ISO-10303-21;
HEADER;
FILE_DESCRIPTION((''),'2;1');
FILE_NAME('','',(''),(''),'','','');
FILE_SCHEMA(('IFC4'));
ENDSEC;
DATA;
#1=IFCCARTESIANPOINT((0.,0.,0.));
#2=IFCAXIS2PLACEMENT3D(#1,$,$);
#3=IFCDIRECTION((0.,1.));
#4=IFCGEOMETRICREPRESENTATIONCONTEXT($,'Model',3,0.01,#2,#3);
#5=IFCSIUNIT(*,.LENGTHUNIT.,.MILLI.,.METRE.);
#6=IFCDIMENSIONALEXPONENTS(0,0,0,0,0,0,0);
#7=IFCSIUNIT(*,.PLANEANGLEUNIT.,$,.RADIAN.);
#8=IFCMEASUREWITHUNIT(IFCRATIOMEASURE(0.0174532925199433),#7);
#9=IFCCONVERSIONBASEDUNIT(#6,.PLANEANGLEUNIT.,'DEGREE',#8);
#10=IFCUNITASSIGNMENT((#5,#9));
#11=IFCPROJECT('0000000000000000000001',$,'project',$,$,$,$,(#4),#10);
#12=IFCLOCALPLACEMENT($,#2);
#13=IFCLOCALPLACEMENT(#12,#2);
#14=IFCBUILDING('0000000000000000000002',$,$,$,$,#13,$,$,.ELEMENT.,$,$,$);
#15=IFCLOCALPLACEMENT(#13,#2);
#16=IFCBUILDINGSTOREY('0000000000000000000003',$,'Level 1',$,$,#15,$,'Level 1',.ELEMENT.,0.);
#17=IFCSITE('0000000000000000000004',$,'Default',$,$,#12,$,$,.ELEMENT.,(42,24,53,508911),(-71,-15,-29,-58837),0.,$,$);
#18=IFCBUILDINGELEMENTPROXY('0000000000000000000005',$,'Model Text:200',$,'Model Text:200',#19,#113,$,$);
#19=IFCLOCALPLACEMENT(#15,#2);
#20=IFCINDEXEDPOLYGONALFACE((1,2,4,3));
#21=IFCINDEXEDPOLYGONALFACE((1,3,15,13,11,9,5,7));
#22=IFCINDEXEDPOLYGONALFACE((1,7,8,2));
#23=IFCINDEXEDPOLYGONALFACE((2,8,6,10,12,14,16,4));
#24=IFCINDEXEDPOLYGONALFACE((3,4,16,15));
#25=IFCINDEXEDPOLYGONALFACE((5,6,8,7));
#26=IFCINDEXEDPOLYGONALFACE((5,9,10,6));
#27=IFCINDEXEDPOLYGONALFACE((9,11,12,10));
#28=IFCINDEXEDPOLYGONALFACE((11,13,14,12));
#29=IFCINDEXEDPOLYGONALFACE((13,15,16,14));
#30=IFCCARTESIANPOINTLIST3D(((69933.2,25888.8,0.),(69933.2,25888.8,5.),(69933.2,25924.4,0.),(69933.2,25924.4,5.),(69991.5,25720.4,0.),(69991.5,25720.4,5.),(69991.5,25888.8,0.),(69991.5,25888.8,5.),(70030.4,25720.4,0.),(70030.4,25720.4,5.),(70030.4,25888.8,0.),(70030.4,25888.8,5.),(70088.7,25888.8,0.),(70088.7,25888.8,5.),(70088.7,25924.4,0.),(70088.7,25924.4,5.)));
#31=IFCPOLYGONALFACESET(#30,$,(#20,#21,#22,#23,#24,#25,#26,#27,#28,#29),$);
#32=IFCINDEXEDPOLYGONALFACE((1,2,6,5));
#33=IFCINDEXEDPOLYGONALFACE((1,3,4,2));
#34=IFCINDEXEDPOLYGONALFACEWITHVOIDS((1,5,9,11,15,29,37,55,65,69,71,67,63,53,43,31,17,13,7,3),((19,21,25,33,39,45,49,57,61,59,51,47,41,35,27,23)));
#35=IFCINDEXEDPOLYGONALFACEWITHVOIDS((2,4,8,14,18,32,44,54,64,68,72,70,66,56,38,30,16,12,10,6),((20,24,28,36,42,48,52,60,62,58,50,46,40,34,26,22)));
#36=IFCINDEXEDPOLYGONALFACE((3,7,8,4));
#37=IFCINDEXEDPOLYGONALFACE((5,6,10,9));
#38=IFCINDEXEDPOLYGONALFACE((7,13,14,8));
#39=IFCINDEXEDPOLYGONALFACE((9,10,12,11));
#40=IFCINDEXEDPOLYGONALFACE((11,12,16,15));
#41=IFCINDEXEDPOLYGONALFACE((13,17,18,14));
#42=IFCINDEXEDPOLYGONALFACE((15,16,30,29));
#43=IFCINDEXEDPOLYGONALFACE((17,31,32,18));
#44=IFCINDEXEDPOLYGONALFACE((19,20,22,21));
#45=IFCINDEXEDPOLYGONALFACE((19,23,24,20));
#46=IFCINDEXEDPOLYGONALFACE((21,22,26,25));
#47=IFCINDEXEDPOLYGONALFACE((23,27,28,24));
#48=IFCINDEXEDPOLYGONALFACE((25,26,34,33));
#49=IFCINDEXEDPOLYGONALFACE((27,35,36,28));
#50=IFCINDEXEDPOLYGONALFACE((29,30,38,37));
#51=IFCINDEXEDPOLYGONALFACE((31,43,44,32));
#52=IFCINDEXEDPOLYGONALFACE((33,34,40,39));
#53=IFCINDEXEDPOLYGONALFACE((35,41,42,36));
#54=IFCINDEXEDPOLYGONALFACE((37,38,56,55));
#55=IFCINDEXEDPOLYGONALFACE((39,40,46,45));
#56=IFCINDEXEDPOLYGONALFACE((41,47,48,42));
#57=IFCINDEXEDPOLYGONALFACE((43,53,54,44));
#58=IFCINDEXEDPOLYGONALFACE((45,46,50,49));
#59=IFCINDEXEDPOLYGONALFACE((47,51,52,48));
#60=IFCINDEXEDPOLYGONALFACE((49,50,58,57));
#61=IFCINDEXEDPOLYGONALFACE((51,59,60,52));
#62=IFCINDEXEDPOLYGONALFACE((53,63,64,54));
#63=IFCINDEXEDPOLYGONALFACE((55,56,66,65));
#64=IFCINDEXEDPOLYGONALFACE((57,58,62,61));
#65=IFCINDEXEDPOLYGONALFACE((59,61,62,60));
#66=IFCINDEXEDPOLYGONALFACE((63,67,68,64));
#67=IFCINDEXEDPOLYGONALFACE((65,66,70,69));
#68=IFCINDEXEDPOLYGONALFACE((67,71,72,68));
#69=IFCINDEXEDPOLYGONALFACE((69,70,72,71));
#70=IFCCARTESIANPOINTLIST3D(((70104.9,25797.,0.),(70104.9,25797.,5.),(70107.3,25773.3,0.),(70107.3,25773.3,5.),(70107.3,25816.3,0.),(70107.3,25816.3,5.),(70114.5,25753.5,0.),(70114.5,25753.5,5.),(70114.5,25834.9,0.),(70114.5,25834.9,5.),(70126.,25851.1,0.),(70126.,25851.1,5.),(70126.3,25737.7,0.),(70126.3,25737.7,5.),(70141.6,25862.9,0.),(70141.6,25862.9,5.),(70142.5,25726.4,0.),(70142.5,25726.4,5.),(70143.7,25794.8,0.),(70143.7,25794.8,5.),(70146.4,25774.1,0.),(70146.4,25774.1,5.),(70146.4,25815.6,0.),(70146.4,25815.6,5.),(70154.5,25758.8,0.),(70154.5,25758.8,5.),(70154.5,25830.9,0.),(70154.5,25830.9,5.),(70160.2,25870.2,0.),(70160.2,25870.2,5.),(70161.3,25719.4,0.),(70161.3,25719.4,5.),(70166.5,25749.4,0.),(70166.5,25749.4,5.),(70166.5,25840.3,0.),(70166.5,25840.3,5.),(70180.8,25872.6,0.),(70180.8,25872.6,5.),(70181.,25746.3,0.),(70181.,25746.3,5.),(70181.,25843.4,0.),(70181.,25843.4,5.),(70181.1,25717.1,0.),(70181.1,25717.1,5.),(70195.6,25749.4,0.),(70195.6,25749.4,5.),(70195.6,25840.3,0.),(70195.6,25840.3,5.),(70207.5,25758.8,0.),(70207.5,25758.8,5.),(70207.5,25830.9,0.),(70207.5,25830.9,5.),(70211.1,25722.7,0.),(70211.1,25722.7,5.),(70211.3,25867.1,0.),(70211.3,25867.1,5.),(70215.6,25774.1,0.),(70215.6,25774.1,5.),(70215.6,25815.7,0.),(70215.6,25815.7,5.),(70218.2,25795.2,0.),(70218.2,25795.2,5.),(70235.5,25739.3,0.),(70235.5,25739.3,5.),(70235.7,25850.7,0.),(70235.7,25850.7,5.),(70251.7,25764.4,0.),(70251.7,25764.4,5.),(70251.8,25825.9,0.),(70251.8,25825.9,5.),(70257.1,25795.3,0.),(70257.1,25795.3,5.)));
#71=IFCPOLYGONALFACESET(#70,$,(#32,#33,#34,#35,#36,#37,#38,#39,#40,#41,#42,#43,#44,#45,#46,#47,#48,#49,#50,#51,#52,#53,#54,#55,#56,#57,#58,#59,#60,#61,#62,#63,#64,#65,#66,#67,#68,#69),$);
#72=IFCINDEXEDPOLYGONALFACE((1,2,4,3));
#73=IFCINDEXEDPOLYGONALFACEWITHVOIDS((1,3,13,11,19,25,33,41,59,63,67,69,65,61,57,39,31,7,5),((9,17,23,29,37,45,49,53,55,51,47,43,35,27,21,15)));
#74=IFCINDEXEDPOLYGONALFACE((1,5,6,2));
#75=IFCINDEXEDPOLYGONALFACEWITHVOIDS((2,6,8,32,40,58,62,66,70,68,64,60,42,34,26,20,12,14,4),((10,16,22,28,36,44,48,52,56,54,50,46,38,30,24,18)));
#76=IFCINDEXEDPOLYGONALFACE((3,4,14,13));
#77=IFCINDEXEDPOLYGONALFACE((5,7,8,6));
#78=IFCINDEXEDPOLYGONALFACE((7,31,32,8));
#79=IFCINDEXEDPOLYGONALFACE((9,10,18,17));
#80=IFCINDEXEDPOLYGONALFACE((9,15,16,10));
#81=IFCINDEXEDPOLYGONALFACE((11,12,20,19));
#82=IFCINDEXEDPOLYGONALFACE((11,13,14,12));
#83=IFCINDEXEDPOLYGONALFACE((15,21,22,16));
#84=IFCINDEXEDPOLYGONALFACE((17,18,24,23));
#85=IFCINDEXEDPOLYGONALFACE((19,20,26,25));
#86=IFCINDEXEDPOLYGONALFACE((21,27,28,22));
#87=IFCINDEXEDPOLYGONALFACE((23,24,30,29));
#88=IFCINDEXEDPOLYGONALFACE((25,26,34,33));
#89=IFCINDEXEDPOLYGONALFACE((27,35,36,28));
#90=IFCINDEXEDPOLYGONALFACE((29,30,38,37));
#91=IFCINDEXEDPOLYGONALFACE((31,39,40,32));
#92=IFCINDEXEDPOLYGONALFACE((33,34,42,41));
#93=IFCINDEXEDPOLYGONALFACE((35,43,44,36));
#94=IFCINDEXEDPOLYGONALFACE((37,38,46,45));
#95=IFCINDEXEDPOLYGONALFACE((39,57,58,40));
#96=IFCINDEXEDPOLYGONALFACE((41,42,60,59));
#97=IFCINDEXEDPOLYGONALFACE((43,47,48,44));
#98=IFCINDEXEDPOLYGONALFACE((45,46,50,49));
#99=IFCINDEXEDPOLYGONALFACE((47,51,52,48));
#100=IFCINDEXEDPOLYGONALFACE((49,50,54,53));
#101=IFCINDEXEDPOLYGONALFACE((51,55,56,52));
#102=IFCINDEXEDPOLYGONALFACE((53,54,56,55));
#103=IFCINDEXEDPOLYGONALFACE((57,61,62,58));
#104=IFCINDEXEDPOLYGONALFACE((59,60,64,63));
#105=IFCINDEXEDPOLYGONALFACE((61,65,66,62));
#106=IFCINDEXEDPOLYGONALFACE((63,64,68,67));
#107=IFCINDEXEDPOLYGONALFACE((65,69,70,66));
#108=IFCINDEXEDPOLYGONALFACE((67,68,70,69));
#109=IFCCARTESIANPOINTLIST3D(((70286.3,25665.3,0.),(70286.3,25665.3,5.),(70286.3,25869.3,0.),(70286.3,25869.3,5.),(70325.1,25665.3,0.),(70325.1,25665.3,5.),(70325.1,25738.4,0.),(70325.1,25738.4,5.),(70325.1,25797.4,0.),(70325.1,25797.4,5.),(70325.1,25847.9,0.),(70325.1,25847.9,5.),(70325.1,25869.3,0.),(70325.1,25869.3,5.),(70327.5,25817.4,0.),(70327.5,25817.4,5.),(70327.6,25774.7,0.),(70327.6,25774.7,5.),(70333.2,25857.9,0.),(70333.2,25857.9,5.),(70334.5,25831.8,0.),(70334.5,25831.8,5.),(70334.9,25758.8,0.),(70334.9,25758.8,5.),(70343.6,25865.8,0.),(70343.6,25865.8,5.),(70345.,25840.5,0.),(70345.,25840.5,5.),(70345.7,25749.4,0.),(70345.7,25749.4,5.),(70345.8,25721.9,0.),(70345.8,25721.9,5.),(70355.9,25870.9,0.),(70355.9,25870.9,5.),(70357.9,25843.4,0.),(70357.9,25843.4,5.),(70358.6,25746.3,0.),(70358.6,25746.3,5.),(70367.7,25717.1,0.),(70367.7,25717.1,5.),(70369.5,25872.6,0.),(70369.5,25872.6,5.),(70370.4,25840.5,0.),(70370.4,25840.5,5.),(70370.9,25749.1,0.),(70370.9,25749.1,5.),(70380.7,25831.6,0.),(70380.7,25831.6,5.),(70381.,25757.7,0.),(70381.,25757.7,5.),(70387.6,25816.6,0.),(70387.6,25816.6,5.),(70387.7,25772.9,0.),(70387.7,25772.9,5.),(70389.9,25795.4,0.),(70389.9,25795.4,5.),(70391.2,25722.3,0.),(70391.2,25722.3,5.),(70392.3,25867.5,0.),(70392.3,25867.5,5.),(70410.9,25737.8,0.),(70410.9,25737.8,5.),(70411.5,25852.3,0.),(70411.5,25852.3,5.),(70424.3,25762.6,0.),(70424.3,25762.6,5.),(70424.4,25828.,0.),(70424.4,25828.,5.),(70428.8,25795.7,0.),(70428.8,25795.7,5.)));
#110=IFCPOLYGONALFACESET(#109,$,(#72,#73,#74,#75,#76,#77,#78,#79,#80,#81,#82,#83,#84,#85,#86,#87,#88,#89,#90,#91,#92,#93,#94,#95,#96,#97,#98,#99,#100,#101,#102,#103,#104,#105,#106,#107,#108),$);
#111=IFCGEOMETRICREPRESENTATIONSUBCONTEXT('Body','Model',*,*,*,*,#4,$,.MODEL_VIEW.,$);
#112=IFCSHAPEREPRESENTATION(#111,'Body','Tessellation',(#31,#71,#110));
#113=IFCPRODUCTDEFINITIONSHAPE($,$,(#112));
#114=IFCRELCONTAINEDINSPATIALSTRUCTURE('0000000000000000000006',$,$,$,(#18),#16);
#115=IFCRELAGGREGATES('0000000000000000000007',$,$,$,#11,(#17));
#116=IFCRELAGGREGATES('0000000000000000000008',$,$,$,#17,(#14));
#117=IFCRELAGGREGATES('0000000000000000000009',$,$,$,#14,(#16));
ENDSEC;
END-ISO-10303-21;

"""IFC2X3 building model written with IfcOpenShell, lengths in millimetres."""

from ifc_helpers import new_model, entity, si_unit, converted_unit, direction, frame, origin, place, context, subcontext, project, spatial, polyline, outline, extrude, element, save


model = new_model("IFC2X3")

# Units and contexts
model_context = context("Model", 3, precision=0.01, world=origin(), true_north=direction((0.0, 1.0)))
body_context = subcontext(model_context, "Body", "Model", "MODEL_VIEW")
ifc_project = project(units=[si_unit("LENGTHUNIT", "METRE", prefix="MILLI"), converted_unit("PLANEANGLEUNIT", "DEGREE", entity("IfcRatioMeasure", 0.0174532925199433), si_unit("PLANEANGLEUNIT", "RADIAN"), dimensions=[0, 0, 0, 0, 0, 0, 0])], contexts=[model_context])

# Site, building, storey
site_placement = place(None, origin())
site = spatial("IfcSite", under=ifc_project, at=site_placement, Name="Default", CompositionType="ELEMENT", RefLatitude=(42, 24, 53, 508911), RefLongitude=(-71, -15, -29, -58837), RefElevation=0.0)
building_placement = place(site_placement, origin())
building = spatial("IfcBuilding", under=site, at=building_placement, CompositionType="ELEMENT")
storey_placement = place(building_placement, origin())
storey = spatial("IfcBuildingStorey", under=building, at=storey_placement, Name="Level 1", LongName="Level 1", CompositionType="ELEMENT", Elevation=0.0)

# Building element proxy
proxy_1_placement = place(storey_placement, origin())
element("IfcBuildingElementProxy", 1, at=proxy_1_placement, inside=storey, Name="Model Text:200", ObjectType="Model Text:200", context=body_context, shape_type="SweptSolid", body=[
    extrude(outline(polyline([(-19.4, -135.2), (19.4, -135.2), (19.4, 33.2), (77.7, 33.2), (77.7, 68.8), (-77.7, 68.8), (-77.7, 33.2), (-19.4, 33.2), (-19.4, -135.2)])), frame((70010.9, 25855.6, 0.0)), (0.0, 0.0, 1.0), 5.0),
    extrude(outline(polyline([(-8.8, -65.7), (15.1, -65.7), (35.5, -60.5), (52.3, -50.4), (65.3, -35.4), (74.1, -17.3), (78.4, 2.1), (75.9, 32.5), (61.8, 58.5), (38.4, 77.1), (8.3, 85.6), (-22.7, 83.3), (-49.0, 69.9), (-67.8, 47.3), (-76.3, 17.5), (-76.0, -3.3), (-70.7, -22.5), (-60.5, -39.2), (-45.5, -52.3), (-27.7, -61.4), (-8.8, -65.7)]), holes=[polyline([(-2.7, -27.2), (-23.1, -22.5), (-37.5, -12.9), (-45.7, 0.0), (-47.3, 14.8), (-42.7, 28.9), (-32.2, 39.9), (-16.3, 46.3), (4.5, 46.9), (25.1, 42.1), (39.6, 32.6), (47.7, 19.7), (49.4, 5.0), (44.8, -9.2), (34.2, -20.2), (18.2, -26.7), (-2.7, -27.2)])]), frame((70171.1, 25794.9, 0.0), z_axis=(0.0, 0.0, 1.0), x_axis=(0.100608, -0.994926, 0.0)), (0.0, 0.0, 1.0), 5.0),
    extrude(outline(polyline([(-73.1, -75.4), (130.9, -75.4), (130.9, -36.6), (57.8, -36.6), (74.3, -15.9), (79.1, 6.0), (73.9, 29.5), (58.4, 49.2), (33.6, 62.6), (0.5, 67.1), (-31.8, 62.8), (-56.1, 49.8), (-71.3, 30.7), (-76.4, 7.8), (-74.7, -5.8), (-69.6, -18.1), (-61.7, -28.5), (-51.7, -36.6), (-73.1, -36.6), (-73.1, -75.4)]), holes=[polyline([(-1.2, -36.6), (-21.2, -34.2), (-35.6, -27.2), (-44.3, -16.7), (-47.2, -3.8), (-44.3, 8.7), (-35.4, 19.0), (-20.4, 25.9), (0.8, 28.2), (23.3, 26.0), (38.5, 19.3), (47.1, 9.2), (49.9, -3.1), (46.8, -16.0), (37.4, -26.8), (21.5, -34.1), (-1.2, -36.6)])]), frame((70361.7, 25796.2, 0.0), z_axis=(0.0, 0.0, 1.0), x_axis=(0.0, -1.0, 0.0)), (0.0, 0.0, 1.0), 5.0),
])

save(model, "model.ifc")
